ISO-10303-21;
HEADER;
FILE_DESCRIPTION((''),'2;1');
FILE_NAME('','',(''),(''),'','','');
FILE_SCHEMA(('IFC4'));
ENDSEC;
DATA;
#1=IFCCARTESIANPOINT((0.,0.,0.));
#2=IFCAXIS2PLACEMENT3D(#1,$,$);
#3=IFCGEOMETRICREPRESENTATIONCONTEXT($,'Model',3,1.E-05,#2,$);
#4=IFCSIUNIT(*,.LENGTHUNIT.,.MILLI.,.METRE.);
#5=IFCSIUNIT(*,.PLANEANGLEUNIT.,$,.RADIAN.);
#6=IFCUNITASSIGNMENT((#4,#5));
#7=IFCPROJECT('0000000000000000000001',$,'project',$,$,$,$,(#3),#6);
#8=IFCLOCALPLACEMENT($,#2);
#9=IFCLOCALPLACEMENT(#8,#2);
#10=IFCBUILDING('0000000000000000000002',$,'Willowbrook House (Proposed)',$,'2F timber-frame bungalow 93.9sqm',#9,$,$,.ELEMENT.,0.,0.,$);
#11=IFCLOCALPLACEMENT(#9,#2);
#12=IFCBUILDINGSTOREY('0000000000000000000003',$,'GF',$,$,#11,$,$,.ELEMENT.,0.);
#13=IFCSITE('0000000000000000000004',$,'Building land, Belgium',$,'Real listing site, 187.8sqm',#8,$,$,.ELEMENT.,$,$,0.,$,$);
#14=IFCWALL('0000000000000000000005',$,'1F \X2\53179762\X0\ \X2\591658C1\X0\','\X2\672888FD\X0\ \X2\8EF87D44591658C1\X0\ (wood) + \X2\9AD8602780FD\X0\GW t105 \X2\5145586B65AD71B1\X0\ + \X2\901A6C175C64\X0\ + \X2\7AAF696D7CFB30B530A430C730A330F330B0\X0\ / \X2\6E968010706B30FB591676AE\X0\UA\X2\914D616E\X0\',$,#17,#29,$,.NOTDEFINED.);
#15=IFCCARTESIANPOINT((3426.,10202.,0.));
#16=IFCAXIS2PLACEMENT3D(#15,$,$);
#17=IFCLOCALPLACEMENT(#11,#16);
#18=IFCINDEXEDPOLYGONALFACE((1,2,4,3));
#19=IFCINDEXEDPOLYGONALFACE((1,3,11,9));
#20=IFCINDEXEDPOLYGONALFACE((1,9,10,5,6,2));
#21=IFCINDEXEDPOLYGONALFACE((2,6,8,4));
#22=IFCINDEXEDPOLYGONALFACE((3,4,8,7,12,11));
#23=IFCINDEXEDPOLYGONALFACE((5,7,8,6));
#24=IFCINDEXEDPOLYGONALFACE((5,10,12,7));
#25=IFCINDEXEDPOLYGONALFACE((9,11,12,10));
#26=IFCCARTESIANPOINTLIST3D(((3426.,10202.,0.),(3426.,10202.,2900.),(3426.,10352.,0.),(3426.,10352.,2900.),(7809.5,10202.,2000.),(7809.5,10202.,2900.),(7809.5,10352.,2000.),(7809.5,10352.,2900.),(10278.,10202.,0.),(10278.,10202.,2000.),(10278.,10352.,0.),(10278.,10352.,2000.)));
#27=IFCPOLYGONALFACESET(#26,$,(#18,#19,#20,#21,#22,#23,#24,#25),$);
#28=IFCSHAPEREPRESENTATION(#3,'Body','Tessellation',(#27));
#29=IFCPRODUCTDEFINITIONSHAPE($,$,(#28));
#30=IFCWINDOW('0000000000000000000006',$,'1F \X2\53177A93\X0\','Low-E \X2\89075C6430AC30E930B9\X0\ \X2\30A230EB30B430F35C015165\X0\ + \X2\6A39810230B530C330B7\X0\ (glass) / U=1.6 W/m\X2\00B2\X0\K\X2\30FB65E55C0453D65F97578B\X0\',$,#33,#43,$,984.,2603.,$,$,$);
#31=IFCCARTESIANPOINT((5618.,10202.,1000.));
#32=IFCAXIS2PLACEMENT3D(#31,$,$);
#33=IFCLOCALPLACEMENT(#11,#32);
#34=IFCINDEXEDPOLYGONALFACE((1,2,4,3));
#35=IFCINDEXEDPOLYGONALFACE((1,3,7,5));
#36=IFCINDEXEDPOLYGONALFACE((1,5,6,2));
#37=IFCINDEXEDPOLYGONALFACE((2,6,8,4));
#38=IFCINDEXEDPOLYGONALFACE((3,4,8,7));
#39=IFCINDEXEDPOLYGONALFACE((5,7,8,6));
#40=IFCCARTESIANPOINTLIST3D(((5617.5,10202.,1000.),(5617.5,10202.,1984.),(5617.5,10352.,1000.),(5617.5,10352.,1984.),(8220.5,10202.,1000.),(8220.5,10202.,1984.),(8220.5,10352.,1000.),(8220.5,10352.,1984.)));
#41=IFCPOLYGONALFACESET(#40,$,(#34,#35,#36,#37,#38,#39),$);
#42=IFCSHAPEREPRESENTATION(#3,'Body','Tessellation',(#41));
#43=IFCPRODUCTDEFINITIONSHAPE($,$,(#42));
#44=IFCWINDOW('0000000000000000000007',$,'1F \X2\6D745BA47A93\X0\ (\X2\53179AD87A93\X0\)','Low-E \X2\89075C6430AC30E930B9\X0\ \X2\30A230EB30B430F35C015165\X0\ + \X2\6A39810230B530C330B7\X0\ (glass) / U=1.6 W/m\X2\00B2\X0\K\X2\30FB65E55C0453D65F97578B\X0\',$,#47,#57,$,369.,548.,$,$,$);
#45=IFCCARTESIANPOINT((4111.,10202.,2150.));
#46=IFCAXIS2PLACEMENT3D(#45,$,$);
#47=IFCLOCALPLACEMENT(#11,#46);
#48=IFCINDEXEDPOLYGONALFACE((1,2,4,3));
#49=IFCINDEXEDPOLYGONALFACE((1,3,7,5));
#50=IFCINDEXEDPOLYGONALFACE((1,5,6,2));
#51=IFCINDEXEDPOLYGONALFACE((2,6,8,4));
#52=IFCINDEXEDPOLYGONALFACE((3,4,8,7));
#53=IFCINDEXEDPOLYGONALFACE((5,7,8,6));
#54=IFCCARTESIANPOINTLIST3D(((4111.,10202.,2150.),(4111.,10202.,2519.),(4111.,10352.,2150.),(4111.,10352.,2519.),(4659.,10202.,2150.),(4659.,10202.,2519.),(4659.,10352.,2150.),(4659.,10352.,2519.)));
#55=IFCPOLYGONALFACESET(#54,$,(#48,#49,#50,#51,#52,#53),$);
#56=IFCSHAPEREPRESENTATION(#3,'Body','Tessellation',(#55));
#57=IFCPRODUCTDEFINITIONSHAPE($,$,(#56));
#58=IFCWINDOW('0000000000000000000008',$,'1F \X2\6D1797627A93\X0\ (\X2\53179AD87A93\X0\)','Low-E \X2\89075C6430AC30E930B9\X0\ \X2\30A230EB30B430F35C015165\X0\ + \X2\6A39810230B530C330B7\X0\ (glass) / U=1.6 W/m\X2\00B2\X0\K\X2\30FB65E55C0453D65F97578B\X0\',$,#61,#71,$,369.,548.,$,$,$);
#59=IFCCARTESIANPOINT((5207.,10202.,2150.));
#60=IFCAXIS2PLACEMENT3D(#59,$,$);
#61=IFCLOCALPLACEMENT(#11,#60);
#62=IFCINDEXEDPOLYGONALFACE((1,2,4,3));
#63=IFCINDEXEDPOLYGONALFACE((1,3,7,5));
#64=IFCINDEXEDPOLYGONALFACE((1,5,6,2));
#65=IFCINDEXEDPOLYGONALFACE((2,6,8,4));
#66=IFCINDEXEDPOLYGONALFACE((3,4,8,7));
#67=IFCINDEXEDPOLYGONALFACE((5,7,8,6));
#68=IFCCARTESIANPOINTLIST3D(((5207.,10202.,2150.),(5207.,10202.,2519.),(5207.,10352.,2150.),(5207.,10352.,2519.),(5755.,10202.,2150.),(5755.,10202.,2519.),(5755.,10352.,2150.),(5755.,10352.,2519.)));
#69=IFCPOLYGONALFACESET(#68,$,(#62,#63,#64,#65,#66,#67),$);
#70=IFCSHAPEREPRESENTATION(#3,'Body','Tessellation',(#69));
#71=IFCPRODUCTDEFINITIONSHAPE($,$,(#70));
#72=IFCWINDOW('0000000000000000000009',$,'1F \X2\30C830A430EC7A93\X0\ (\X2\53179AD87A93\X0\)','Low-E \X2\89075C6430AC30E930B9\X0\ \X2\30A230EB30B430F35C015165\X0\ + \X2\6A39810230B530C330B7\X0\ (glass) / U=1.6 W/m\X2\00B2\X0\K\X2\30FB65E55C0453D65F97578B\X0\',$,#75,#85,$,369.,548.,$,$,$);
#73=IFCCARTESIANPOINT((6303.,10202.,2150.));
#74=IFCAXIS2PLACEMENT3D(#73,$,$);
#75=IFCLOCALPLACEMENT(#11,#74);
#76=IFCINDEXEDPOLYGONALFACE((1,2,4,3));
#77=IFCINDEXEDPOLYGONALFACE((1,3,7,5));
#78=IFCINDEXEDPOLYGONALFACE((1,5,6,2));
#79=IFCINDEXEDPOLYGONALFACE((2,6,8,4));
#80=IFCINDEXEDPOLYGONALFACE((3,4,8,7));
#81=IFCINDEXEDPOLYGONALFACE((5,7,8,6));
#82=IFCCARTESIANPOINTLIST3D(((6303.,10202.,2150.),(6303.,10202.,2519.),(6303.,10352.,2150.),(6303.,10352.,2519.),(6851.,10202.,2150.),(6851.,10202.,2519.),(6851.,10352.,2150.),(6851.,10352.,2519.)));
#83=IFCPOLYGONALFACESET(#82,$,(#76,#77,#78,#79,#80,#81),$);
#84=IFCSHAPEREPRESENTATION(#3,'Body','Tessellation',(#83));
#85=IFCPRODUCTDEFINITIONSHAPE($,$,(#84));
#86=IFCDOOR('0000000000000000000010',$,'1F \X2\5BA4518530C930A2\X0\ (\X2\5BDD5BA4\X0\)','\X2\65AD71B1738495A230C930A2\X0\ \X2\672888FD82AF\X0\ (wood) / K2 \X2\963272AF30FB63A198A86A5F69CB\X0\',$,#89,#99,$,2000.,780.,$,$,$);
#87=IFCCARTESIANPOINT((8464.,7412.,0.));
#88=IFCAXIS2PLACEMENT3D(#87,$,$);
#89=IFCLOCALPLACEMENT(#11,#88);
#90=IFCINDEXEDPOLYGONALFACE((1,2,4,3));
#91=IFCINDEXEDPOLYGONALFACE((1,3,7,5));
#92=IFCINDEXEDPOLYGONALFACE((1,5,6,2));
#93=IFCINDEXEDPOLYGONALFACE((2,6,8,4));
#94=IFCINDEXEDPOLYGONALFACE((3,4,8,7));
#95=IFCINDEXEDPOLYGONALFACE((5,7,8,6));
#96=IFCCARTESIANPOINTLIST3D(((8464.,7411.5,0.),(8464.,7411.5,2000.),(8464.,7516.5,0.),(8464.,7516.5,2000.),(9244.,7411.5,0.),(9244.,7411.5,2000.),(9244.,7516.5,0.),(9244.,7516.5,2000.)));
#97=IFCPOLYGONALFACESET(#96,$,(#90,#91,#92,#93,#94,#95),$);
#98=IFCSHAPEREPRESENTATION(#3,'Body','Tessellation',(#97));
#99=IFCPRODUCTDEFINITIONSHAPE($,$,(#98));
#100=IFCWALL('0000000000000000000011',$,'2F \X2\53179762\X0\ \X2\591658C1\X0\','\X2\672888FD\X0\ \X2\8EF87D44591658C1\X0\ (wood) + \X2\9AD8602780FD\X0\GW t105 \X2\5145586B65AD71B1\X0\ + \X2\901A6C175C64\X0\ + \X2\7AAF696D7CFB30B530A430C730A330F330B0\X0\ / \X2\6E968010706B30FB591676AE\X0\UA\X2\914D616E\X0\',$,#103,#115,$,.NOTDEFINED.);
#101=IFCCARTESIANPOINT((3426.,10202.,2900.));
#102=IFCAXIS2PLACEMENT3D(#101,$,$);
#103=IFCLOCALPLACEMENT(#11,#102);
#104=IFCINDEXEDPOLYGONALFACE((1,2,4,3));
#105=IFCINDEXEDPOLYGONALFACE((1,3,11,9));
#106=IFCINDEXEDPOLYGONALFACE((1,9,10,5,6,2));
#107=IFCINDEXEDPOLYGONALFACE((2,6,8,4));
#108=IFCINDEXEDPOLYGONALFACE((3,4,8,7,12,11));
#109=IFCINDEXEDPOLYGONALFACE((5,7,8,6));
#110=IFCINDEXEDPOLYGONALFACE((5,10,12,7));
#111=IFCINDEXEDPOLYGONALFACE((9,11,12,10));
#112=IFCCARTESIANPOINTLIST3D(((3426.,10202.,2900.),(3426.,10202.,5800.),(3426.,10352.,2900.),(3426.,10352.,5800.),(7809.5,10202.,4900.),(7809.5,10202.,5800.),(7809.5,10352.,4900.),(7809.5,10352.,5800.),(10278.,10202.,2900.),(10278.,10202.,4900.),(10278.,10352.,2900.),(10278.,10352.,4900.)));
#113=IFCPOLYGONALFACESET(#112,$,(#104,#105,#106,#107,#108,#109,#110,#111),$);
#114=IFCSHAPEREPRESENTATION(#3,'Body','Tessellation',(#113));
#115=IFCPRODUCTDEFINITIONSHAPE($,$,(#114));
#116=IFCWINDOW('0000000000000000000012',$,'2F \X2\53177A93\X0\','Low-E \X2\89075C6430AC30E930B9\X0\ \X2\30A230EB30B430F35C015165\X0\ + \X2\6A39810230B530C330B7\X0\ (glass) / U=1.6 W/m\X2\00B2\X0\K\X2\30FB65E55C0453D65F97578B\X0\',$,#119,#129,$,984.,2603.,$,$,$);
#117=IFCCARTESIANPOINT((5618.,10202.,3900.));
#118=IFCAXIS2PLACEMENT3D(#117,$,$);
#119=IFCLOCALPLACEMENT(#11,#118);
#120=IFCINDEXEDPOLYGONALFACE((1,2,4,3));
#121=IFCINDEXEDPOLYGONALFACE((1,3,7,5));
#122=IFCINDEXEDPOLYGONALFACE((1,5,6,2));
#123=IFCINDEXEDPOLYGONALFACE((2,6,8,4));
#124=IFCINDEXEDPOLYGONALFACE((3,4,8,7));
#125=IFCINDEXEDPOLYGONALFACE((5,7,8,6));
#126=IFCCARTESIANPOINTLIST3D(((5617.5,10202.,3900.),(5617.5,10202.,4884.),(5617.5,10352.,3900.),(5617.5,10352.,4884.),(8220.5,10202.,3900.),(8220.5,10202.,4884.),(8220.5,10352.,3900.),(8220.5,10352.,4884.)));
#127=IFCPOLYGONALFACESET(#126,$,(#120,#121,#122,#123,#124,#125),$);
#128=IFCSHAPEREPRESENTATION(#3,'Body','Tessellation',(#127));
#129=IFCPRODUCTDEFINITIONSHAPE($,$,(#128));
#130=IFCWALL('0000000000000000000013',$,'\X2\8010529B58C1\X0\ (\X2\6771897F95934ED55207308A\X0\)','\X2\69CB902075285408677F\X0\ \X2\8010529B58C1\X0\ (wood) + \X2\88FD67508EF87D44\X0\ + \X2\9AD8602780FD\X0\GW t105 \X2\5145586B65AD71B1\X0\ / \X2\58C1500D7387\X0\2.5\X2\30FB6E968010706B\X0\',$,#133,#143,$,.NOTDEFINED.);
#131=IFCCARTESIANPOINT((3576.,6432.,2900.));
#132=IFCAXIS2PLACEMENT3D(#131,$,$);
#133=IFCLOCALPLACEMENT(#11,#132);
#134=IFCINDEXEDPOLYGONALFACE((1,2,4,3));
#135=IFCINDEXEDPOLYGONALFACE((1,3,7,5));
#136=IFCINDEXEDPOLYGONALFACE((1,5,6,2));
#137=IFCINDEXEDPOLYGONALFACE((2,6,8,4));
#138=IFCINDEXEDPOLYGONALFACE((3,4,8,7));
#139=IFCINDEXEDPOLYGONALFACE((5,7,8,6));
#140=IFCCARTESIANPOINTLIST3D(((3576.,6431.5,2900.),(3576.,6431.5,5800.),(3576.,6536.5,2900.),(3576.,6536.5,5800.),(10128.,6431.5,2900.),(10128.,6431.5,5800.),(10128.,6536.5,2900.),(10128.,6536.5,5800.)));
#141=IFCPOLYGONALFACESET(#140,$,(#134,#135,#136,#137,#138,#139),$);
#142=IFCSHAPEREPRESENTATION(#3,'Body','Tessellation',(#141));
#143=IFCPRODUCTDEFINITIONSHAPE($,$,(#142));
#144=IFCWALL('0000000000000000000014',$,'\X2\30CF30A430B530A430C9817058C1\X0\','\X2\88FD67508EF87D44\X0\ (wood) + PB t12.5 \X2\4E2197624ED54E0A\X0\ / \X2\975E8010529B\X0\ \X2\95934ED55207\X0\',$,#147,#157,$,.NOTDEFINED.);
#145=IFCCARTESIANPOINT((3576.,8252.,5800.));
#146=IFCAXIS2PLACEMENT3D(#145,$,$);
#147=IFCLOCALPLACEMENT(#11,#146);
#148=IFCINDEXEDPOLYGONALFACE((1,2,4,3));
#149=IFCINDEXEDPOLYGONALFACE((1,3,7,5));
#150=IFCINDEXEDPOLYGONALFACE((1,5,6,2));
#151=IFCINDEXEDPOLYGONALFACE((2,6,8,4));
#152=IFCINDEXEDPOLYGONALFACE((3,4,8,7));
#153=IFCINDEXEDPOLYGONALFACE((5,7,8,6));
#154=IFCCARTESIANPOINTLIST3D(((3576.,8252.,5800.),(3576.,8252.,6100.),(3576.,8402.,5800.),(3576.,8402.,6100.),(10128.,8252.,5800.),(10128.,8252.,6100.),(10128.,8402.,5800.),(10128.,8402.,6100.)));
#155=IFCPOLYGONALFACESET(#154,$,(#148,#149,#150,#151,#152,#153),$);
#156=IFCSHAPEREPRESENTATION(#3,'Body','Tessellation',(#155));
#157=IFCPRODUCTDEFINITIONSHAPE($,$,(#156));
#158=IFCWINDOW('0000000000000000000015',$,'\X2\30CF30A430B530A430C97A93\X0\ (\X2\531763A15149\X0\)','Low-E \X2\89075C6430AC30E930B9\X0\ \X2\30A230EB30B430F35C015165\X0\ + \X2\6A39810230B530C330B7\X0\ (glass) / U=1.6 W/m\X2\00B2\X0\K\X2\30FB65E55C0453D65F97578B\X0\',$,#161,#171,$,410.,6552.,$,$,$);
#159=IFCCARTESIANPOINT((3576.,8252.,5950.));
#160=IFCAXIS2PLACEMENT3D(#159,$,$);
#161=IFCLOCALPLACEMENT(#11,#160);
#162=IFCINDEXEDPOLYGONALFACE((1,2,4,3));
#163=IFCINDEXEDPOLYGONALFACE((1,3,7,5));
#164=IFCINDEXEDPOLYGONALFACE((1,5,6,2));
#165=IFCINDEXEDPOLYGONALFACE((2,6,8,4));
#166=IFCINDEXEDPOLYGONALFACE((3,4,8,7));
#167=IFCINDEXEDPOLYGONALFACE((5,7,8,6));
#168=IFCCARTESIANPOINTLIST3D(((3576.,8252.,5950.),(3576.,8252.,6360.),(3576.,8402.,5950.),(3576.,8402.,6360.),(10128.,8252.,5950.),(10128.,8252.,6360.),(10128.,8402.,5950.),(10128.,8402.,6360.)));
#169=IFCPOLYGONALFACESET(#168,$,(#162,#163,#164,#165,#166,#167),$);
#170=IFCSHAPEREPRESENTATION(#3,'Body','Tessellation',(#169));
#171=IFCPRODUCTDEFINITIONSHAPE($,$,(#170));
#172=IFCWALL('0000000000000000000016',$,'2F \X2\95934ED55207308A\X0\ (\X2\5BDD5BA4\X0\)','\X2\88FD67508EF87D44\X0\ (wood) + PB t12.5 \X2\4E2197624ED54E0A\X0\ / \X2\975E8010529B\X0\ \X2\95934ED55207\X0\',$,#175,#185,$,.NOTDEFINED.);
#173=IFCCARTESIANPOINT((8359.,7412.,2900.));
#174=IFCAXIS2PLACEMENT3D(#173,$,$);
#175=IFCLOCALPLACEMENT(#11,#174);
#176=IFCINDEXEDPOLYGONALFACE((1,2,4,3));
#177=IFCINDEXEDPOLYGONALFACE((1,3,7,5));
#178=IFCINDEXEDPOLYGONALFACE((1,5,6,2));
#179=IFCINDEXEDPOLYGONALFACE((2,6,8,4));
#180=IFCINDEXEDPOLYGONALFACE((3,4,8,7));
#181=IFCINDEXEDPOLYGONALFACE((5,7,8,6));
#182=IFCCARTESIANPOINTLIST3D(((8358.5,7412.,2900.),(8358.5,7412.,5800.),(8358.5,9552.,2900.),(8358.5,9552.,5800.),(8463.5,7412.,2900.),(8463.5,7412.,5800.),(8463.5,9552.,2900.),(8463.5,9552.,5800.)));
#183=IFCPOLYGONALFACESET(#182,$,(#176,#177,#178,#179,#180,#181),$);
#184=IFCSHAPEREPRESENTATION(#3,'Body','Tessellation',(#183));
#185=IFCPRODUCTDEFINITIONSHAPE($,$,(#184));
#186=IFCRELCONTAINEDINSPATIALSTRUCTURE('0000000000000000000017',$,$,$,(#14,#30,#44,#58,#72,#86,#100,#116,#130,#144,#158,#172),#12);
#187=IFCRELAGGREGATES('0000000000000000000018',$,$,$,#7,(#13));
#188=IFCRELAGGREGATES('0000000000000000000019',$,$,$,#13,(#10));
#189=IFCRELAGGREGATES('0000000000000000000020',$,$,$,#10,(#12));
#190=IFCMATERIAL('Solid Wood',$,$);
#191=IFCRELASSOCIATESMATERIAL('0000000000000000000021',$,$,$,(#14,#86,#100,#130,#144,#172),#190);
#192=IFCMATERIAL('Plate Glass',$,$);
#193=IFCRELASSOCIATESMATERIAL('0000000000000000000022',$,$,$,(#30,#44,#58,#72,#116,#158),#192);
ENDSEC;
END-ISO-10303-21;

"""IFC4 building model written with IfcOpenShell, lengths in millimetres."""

from ifc_helpers import new_model, si_unit, frame, frame_2d, origin, place, context, project, spatial, rectangle, extrude, material, element, fill, save


model = new_model("IFC4")

# Units and contexts
model_context = context("Model", 3, precision=1e-05, world=origin())
ifc_project = project(units=[si_unit("LENGTHUNIT", "METRE", prefix="MILLI"), si_unit("PLANEANGLEUNIT", "RADIAN")], contexts=[model_context])

# Site, building, storey
site_placement = place(None, origin())
site = spatial("IfcSite", under=ifc_project, at=site_placement, Name="Building land, Belgium", ObjectType="Real listing site, 187.8sqm", CompositionType="ELEMENT", RefElevation=0.0)
building_placement = place(site_placement, origin())
building = spatial("IfcBuilding", under=site, at=building_placement, Name="Willowbrook House (Proposed)", ObjectType="2F timber-frame bungalow 93.9sqm", CompositionType="ELEMENT", ElevationOfRefHeight=0.0, ElevationOfTerrain=0.0)
storey_placement = place(building_placement, origin())
storey = spatial("IfcBuildingStorey", under=building, at=storey_placement, Name="GF", CompositionType="ELEMENT", Elevation=0.0)

# Wall, openings, windows
ifc_material_1 = material(Name="Solid Wood")
wall_1_placement = place(storey_placement, frame((3426.0, 10202.0, 0.0)))
wall_1 = element("IfcWall", 1, at=wall_1_placement, inside=storey, material=ifc_material_1, Name="1F 北面 外壁", Description="木製 軸組外壁 (wood) + 高性能GW t105 充填断熱 + 通気層 + 窯業系サイディング / 準耐火・外皮UA配慮", PredefinedType="NOTDEFINED", context=model_context, shape_type="SweptSolid", body=[
    extrude(rectangle(XDim=6852.0, YDim=150.0, at=frame_2d((3426.0, 75.0))), frame((3426.0, 10202.0, 0.0)), (0.0, 0.0, 1.0), 2900.0),
])
opening_1_placement = place(storey_placement, frame((5618.0, 10202.0, 1000.0)))
opening_1 = element("IfcOpeningElement", 2, at=opening_1_placement, cuts=wall_1, PredefinedType="NOTDEFINED", context=model_context, shape_type="SweptSolid", body=[
    extrude(rectangle(XDim=2603.0, YDim=150.0, at=frame_2d((1301.0, 75.0))), frame((5618.0, 10202.0, 1000.0)), (0.0, 0.0, 1.0), 984.0),
])
opening_2_placement = place(storey_placement, frame((4111.0, 10202.0, 2150.0)))
opening_2 = element("IfcOpeningElement", 3, at=opening_2_placement, cuts=wall_1, PredefinedType="NOTDEFINED", context=model_context, shape_type="SweptSolid", body=[
    extrude(rectangle(XDim=548.0, YDim=150.0, at=frame_2d((274.0, 75.0))), frame((4111.0, 10202.0, 2150.0)), (0.0, 0.0, 1.0), 369.0),
])
opening_3_placement = place(storey_placement, frame((5207.0, 10202.0, 2150.0)))
opening_3 = element("IfcOpeningElement", 4, at=opening_3_placement, cuts=wall_1, PredefinedType="NOTDEFINED", context=model_context, shape_type="SweptSolid", body=[
    extrude(rectangle(XDim=548.0, YDim=150.0, at=frame_2d((274.0, 75.0))), frame((5207.0, 10202.0, 2150.0)), (0.0, 0.0, 1.0), 369.0),
])
opening_4_placement = place(storey_placement, frame((6303.0, 10202.0, 2150.0)))
opening_4 = element("IfcOpeningElement", 5, at=opening_4_placement, cuts=wall_1, PredefinedType="NOTDEFINED", context=model_context, shape_type="SweptSolid", body=[
    extrude(rectangle(XDim=548.0, YDim=150.0, at=frame_2d((274.0, 75.0))), frame((6303.0, 10202.0, 2150.0)), (0.0, 0.0, 1.0), 369.0),
])
ifc_material_2 = material(Name="Plate Glass")
window_1_placement = place(storey_placement, frame((5618.0, 10202.0, 1000.0)))
window_1 = element("IfcWindow", 6, at=window_1_placement, inside=storey, material=ifc_material_2, Name="1F 北窓", Description="Low-E 複層ガラス アルゴン封入 + 樹脂サッシ (glass) / U=1.6 W/m²K・日射取得型", OverallHeight=984.0, OverallWidth=2603.0, context=model_context, shape_type="SweptSolid", body=[
    extrude(rectangle(XDim=2603.0, YDim=150.0, at=frame_2d((1301.0, 75.0))), frame((5618.0, 10202.0, 1000.0)), (0.0, 0.0, 1.0), 984.0),
])
fill(opening_1, window_1)
window_2_placement = place(storey_placement, frame((4111.0, 10202.0, 2150.0)))
window_2 = element("IfcWindow", 7, at=window_2_placement, inside=storey, material=ifc_material_2, Name="1F 浴室窓 (北高窓)", Description="Low-E 複層ガラス アルゴン封入 + 樹脂サッシ (glass) / U=1.6 W/m²K・日射取得型", OverallHeight=369.0, OverallWidth=548.0, context=model_context, shape_type="SweptSolid", body=[
    extrude(rectangle(XDim=548.0, YDim=150.0, at=frame_2d((274.0, 75.0))), frame((4111.0, 10202.0, 2150.0)), (0.0, 0.0, 1.0), 369.0),
])
fill(opening_2, window_2)
window_3_placement = place(storey_placement, frame((5207.0, 10202.0, 2150.0)))
window_3 = element("IfcWindow", 8, at=window_3_placement, inside=storey, material=ifc_material_2, Name="1F 洗面窓 (北高窓)", Description="Low-E 複層ガラス アルゴン封入 + 樹脂サッシ (glass) / U=1.6 W/m²K・日射取得型", OverallHeight=369.0, OverallWidth=548.0, context=model_context, shape_type="SweptSolid", body=[
    extrude(rectangle(XDim=548.0, YDim=150.0, at=frame_2d((274.0, 75.0))), frame((5207.0, 10202.0, 2150.0)), (0.0, 0.0, 1.0), 369.0),
])
fill(opening_3, window_3)
window_4_placement = place(storey_placement, frame((6303.0, 10202.0, 2150.0)))
window_4 = element("IfcWindow", 9, at=window_4_placement, inside=storey, material=ifc_material_2, Name="1F トイレ窓 (北高窓)", Description="Low-E 複層ガラス アルゴン封入 + 樹脂サッシ (glass) / U=1.6 W/m²K・日射取得型", OverallHeight=369.0, OverallWidth=548.0, context=model_context, shape_type="SweptSolid", body=[
    extrude(rectangle(XDim=548.0, YDim=150.0, at=frame_2d((274.0, 75.0))), frame((6303.0, 10202.0, 2150.0)), (0.0, 0.0, 1.0), 369.0),
])
fill(opening_4, window_4)

# Door
door_1_placement = place(storey_placement, frame((8464.0, 7412.0, 0.0)))
element("IfcDoor", 10, at=door_1_placement, inside=storey, material=ifc_material_1, Name="1F 室内ドア (寝室)", Description="断熱玄関ドア 木製芯 (wood) / K2 防犯・採風機構", OverallHeight=2000.0, OverallWidth=780.0, context=model_context, shape_type="SweptSolid", body=[
    extrude(rectangle(XDim=780.0, YDim=105.0, at=frame_2d((390.0, 52.0))), frame((8464.0, 7412.0, 0.0)), (0.0, 0.0, 1.0), 2000.0),
])

# Wall, opening, window
wall_2_placement = place(storey_placement, frame((3426.0, 10202.0, 2900.0)))
wall_2 = element("IfcWall", 11, at=wall_2_placement, inside=storey, material=ifc_material_1, Name="2F 北面 外壁", Description="木製 軸組外壁 (wood) + 高性能GW t105 充填断熱 + 通気層 + 窯業系サイディング / 準耐火・外皮UA配慮", PredefinedType="NOTDEFINED", context=model_context, shape_type="SweptSolid", body=[
    extrude(rectangle(XDim=6852.0, YDim=150.0, at=frame_2d((3426.0, 75.0))), frame((3426.0, 10202.0, 2900.0)), (0.0, 0.0, 1.0), 2900.0),
])
opening_5_placement = place(storey_placement, frame((5618.0, 10202.0, 3900.0)))
opening_5 = element("IfcOpeningElement", 12, at=opening_5_placement, cuts=wall_2, PredefinedType="NOTDEFINED", context=model_context, shape_type="SweptSolid", body=[
    extrude(rectangle(XDim=2603.0, YDim=150.0, at=frame_2d((1301.0, 75.0))), frame((5618.0, 10202.0, 3900.0)), (0.0, 0.0, 1.0), 984.0),
])
window_5_placement = place(storey_placement, frame((5618.0, 10202.0, 3900.0)))
window_5 = element("IfcWindow", 13, at=window_5_placement, inside=storey, material=ifc_material_2, Name="2F 北窓", Description="Low-E 複層ガラス アルゴン封入 + 樹脂サッシ (glass) / U=1.6 W/m²K・日射取得型", OverallHeight=984.0, OverallWidth=2603.0, context=model_context, shape_type="SweptSolid", body=[
    extrude(rectangle(XDim=2603.0, YDim=150.0, at=frame_2d((1301.0, 75.0))), frame((5618.0, 10202.0, 3900.0)), (0.0, 0.0, 1.0), 984.0),
])
fill(opening_5, window_5)

# Wall
wall_3_placement = place(storey_placement, frame((3576.0, 6432.0, 2900.0)))
element("IfcWall", 14, at=wall_3_placement, inside=storey, material=ifc_material_1, Name="耐力壁 (東西間仕切り)", Description="構造用合板 耐力壁 (wood) + 製材軸組 + 高性能GW t105 充填断熱 / 壁倍率2.5・準耐火", PredefinedType="NOTDEFINED", context=model_context, shape_type="SweptSolid", body=[
    extrude(rectangle(XDim=6552.0, YDim=105.0, at=frame_2d((3276.0, 52.0))), frame((3576.0, 6432.0, 2900.0)), (0.0, 0.0, 1.0), 2900.0),
])

# Wall, opening, window
wall_4_placement = place(storey_placement, frame((3576.0, 8252.0, 5800.0)))
wall_4 = element("IfcWall", 15, at=wall_4_placement, inside=storey, material=ifc_material_1, Name="ハイサイド腰壁", Description="製材軸組 (wood) + PB t12.5 両面仕上 / 非耐力 間仕切", PredefinedType="NOTDEFINED", context=model_context, shape_type="SweptSolid", body=[
    extrude(rectangle(XDim=6552.0, YDim=150.0, at=frame_2d((3276.0, 75.0))), frame((3576.0, 8252.0, 5800.0)), (0.0, 0.0, 1.0), 700.0),
])
opening_6_placement = place(storey_placement, frame((3576.0, 8252.0, 5950.0)))
opening_6 = element("IfcOpeningElement", 16, at=opening_6_placement, cuts=wall_4, PredefinedType="NOTDEFINED", context=model_context, shape_type="SweptSolid", body=[
    extrude(rectangle(XDim=6552.0, YDim=150.0, at=frame_2d((3276.0, 75.0))), frame((3576.0, 8252.0, 5950.0)), (0.0, 0.0, 1.0), 410.0),
])
window_6_placement = place(storey_placement, frame((3576.0, 8252.0, 5950.0)))
window_6 = element("IfcWindow", 17, at=window_6_placement, inside=storey, material=ifc_material_2, Name="ハイサイド窓 (北採光)", Description="Low-E 複層ガラス アルゴン封入 + 樹脂サッシ (glass) / U=1.6 W/m²K・日射取得型", OverallHeight=410.0, OverallWidth=6552.0, context=model_context, shape_type="SweptSolid", body=[
    extrude(rectangle(XDim=6552.0, YDim=150.0, at=frame_2d((3276.0, 75.0))), frame((3576.0, 8252.0, 5950.0)), (0.0, 0.0, 1.0), 410.0),
])
fill(opening_6, window_6)

# Wall
wall_5_placement = place(storey_placement, frame((8359.0, 7412.0, 2900.0)))
element("IfcWall", 18, at=wall_5_placement, inside=storey, material=ifc_material_1, Name="2F 間仕切り (寝室)", Description="製材軸組 (wood) + PB t12.5 両面仕上 / 非耐力 間仕切", PredefinedType="NOTDEFINED", context=model_context, shape_type="SweptSolid", body=[
    extrude(rectangle(XDim=105.0, YDim=2140.0, at=frame_2d((52.0, 1070.0))), frame((8359.0, 7412.0, 2900.0)), (0.0, 0.0, 1.0), 2900.0),
])

save(model, "model.ifc")
